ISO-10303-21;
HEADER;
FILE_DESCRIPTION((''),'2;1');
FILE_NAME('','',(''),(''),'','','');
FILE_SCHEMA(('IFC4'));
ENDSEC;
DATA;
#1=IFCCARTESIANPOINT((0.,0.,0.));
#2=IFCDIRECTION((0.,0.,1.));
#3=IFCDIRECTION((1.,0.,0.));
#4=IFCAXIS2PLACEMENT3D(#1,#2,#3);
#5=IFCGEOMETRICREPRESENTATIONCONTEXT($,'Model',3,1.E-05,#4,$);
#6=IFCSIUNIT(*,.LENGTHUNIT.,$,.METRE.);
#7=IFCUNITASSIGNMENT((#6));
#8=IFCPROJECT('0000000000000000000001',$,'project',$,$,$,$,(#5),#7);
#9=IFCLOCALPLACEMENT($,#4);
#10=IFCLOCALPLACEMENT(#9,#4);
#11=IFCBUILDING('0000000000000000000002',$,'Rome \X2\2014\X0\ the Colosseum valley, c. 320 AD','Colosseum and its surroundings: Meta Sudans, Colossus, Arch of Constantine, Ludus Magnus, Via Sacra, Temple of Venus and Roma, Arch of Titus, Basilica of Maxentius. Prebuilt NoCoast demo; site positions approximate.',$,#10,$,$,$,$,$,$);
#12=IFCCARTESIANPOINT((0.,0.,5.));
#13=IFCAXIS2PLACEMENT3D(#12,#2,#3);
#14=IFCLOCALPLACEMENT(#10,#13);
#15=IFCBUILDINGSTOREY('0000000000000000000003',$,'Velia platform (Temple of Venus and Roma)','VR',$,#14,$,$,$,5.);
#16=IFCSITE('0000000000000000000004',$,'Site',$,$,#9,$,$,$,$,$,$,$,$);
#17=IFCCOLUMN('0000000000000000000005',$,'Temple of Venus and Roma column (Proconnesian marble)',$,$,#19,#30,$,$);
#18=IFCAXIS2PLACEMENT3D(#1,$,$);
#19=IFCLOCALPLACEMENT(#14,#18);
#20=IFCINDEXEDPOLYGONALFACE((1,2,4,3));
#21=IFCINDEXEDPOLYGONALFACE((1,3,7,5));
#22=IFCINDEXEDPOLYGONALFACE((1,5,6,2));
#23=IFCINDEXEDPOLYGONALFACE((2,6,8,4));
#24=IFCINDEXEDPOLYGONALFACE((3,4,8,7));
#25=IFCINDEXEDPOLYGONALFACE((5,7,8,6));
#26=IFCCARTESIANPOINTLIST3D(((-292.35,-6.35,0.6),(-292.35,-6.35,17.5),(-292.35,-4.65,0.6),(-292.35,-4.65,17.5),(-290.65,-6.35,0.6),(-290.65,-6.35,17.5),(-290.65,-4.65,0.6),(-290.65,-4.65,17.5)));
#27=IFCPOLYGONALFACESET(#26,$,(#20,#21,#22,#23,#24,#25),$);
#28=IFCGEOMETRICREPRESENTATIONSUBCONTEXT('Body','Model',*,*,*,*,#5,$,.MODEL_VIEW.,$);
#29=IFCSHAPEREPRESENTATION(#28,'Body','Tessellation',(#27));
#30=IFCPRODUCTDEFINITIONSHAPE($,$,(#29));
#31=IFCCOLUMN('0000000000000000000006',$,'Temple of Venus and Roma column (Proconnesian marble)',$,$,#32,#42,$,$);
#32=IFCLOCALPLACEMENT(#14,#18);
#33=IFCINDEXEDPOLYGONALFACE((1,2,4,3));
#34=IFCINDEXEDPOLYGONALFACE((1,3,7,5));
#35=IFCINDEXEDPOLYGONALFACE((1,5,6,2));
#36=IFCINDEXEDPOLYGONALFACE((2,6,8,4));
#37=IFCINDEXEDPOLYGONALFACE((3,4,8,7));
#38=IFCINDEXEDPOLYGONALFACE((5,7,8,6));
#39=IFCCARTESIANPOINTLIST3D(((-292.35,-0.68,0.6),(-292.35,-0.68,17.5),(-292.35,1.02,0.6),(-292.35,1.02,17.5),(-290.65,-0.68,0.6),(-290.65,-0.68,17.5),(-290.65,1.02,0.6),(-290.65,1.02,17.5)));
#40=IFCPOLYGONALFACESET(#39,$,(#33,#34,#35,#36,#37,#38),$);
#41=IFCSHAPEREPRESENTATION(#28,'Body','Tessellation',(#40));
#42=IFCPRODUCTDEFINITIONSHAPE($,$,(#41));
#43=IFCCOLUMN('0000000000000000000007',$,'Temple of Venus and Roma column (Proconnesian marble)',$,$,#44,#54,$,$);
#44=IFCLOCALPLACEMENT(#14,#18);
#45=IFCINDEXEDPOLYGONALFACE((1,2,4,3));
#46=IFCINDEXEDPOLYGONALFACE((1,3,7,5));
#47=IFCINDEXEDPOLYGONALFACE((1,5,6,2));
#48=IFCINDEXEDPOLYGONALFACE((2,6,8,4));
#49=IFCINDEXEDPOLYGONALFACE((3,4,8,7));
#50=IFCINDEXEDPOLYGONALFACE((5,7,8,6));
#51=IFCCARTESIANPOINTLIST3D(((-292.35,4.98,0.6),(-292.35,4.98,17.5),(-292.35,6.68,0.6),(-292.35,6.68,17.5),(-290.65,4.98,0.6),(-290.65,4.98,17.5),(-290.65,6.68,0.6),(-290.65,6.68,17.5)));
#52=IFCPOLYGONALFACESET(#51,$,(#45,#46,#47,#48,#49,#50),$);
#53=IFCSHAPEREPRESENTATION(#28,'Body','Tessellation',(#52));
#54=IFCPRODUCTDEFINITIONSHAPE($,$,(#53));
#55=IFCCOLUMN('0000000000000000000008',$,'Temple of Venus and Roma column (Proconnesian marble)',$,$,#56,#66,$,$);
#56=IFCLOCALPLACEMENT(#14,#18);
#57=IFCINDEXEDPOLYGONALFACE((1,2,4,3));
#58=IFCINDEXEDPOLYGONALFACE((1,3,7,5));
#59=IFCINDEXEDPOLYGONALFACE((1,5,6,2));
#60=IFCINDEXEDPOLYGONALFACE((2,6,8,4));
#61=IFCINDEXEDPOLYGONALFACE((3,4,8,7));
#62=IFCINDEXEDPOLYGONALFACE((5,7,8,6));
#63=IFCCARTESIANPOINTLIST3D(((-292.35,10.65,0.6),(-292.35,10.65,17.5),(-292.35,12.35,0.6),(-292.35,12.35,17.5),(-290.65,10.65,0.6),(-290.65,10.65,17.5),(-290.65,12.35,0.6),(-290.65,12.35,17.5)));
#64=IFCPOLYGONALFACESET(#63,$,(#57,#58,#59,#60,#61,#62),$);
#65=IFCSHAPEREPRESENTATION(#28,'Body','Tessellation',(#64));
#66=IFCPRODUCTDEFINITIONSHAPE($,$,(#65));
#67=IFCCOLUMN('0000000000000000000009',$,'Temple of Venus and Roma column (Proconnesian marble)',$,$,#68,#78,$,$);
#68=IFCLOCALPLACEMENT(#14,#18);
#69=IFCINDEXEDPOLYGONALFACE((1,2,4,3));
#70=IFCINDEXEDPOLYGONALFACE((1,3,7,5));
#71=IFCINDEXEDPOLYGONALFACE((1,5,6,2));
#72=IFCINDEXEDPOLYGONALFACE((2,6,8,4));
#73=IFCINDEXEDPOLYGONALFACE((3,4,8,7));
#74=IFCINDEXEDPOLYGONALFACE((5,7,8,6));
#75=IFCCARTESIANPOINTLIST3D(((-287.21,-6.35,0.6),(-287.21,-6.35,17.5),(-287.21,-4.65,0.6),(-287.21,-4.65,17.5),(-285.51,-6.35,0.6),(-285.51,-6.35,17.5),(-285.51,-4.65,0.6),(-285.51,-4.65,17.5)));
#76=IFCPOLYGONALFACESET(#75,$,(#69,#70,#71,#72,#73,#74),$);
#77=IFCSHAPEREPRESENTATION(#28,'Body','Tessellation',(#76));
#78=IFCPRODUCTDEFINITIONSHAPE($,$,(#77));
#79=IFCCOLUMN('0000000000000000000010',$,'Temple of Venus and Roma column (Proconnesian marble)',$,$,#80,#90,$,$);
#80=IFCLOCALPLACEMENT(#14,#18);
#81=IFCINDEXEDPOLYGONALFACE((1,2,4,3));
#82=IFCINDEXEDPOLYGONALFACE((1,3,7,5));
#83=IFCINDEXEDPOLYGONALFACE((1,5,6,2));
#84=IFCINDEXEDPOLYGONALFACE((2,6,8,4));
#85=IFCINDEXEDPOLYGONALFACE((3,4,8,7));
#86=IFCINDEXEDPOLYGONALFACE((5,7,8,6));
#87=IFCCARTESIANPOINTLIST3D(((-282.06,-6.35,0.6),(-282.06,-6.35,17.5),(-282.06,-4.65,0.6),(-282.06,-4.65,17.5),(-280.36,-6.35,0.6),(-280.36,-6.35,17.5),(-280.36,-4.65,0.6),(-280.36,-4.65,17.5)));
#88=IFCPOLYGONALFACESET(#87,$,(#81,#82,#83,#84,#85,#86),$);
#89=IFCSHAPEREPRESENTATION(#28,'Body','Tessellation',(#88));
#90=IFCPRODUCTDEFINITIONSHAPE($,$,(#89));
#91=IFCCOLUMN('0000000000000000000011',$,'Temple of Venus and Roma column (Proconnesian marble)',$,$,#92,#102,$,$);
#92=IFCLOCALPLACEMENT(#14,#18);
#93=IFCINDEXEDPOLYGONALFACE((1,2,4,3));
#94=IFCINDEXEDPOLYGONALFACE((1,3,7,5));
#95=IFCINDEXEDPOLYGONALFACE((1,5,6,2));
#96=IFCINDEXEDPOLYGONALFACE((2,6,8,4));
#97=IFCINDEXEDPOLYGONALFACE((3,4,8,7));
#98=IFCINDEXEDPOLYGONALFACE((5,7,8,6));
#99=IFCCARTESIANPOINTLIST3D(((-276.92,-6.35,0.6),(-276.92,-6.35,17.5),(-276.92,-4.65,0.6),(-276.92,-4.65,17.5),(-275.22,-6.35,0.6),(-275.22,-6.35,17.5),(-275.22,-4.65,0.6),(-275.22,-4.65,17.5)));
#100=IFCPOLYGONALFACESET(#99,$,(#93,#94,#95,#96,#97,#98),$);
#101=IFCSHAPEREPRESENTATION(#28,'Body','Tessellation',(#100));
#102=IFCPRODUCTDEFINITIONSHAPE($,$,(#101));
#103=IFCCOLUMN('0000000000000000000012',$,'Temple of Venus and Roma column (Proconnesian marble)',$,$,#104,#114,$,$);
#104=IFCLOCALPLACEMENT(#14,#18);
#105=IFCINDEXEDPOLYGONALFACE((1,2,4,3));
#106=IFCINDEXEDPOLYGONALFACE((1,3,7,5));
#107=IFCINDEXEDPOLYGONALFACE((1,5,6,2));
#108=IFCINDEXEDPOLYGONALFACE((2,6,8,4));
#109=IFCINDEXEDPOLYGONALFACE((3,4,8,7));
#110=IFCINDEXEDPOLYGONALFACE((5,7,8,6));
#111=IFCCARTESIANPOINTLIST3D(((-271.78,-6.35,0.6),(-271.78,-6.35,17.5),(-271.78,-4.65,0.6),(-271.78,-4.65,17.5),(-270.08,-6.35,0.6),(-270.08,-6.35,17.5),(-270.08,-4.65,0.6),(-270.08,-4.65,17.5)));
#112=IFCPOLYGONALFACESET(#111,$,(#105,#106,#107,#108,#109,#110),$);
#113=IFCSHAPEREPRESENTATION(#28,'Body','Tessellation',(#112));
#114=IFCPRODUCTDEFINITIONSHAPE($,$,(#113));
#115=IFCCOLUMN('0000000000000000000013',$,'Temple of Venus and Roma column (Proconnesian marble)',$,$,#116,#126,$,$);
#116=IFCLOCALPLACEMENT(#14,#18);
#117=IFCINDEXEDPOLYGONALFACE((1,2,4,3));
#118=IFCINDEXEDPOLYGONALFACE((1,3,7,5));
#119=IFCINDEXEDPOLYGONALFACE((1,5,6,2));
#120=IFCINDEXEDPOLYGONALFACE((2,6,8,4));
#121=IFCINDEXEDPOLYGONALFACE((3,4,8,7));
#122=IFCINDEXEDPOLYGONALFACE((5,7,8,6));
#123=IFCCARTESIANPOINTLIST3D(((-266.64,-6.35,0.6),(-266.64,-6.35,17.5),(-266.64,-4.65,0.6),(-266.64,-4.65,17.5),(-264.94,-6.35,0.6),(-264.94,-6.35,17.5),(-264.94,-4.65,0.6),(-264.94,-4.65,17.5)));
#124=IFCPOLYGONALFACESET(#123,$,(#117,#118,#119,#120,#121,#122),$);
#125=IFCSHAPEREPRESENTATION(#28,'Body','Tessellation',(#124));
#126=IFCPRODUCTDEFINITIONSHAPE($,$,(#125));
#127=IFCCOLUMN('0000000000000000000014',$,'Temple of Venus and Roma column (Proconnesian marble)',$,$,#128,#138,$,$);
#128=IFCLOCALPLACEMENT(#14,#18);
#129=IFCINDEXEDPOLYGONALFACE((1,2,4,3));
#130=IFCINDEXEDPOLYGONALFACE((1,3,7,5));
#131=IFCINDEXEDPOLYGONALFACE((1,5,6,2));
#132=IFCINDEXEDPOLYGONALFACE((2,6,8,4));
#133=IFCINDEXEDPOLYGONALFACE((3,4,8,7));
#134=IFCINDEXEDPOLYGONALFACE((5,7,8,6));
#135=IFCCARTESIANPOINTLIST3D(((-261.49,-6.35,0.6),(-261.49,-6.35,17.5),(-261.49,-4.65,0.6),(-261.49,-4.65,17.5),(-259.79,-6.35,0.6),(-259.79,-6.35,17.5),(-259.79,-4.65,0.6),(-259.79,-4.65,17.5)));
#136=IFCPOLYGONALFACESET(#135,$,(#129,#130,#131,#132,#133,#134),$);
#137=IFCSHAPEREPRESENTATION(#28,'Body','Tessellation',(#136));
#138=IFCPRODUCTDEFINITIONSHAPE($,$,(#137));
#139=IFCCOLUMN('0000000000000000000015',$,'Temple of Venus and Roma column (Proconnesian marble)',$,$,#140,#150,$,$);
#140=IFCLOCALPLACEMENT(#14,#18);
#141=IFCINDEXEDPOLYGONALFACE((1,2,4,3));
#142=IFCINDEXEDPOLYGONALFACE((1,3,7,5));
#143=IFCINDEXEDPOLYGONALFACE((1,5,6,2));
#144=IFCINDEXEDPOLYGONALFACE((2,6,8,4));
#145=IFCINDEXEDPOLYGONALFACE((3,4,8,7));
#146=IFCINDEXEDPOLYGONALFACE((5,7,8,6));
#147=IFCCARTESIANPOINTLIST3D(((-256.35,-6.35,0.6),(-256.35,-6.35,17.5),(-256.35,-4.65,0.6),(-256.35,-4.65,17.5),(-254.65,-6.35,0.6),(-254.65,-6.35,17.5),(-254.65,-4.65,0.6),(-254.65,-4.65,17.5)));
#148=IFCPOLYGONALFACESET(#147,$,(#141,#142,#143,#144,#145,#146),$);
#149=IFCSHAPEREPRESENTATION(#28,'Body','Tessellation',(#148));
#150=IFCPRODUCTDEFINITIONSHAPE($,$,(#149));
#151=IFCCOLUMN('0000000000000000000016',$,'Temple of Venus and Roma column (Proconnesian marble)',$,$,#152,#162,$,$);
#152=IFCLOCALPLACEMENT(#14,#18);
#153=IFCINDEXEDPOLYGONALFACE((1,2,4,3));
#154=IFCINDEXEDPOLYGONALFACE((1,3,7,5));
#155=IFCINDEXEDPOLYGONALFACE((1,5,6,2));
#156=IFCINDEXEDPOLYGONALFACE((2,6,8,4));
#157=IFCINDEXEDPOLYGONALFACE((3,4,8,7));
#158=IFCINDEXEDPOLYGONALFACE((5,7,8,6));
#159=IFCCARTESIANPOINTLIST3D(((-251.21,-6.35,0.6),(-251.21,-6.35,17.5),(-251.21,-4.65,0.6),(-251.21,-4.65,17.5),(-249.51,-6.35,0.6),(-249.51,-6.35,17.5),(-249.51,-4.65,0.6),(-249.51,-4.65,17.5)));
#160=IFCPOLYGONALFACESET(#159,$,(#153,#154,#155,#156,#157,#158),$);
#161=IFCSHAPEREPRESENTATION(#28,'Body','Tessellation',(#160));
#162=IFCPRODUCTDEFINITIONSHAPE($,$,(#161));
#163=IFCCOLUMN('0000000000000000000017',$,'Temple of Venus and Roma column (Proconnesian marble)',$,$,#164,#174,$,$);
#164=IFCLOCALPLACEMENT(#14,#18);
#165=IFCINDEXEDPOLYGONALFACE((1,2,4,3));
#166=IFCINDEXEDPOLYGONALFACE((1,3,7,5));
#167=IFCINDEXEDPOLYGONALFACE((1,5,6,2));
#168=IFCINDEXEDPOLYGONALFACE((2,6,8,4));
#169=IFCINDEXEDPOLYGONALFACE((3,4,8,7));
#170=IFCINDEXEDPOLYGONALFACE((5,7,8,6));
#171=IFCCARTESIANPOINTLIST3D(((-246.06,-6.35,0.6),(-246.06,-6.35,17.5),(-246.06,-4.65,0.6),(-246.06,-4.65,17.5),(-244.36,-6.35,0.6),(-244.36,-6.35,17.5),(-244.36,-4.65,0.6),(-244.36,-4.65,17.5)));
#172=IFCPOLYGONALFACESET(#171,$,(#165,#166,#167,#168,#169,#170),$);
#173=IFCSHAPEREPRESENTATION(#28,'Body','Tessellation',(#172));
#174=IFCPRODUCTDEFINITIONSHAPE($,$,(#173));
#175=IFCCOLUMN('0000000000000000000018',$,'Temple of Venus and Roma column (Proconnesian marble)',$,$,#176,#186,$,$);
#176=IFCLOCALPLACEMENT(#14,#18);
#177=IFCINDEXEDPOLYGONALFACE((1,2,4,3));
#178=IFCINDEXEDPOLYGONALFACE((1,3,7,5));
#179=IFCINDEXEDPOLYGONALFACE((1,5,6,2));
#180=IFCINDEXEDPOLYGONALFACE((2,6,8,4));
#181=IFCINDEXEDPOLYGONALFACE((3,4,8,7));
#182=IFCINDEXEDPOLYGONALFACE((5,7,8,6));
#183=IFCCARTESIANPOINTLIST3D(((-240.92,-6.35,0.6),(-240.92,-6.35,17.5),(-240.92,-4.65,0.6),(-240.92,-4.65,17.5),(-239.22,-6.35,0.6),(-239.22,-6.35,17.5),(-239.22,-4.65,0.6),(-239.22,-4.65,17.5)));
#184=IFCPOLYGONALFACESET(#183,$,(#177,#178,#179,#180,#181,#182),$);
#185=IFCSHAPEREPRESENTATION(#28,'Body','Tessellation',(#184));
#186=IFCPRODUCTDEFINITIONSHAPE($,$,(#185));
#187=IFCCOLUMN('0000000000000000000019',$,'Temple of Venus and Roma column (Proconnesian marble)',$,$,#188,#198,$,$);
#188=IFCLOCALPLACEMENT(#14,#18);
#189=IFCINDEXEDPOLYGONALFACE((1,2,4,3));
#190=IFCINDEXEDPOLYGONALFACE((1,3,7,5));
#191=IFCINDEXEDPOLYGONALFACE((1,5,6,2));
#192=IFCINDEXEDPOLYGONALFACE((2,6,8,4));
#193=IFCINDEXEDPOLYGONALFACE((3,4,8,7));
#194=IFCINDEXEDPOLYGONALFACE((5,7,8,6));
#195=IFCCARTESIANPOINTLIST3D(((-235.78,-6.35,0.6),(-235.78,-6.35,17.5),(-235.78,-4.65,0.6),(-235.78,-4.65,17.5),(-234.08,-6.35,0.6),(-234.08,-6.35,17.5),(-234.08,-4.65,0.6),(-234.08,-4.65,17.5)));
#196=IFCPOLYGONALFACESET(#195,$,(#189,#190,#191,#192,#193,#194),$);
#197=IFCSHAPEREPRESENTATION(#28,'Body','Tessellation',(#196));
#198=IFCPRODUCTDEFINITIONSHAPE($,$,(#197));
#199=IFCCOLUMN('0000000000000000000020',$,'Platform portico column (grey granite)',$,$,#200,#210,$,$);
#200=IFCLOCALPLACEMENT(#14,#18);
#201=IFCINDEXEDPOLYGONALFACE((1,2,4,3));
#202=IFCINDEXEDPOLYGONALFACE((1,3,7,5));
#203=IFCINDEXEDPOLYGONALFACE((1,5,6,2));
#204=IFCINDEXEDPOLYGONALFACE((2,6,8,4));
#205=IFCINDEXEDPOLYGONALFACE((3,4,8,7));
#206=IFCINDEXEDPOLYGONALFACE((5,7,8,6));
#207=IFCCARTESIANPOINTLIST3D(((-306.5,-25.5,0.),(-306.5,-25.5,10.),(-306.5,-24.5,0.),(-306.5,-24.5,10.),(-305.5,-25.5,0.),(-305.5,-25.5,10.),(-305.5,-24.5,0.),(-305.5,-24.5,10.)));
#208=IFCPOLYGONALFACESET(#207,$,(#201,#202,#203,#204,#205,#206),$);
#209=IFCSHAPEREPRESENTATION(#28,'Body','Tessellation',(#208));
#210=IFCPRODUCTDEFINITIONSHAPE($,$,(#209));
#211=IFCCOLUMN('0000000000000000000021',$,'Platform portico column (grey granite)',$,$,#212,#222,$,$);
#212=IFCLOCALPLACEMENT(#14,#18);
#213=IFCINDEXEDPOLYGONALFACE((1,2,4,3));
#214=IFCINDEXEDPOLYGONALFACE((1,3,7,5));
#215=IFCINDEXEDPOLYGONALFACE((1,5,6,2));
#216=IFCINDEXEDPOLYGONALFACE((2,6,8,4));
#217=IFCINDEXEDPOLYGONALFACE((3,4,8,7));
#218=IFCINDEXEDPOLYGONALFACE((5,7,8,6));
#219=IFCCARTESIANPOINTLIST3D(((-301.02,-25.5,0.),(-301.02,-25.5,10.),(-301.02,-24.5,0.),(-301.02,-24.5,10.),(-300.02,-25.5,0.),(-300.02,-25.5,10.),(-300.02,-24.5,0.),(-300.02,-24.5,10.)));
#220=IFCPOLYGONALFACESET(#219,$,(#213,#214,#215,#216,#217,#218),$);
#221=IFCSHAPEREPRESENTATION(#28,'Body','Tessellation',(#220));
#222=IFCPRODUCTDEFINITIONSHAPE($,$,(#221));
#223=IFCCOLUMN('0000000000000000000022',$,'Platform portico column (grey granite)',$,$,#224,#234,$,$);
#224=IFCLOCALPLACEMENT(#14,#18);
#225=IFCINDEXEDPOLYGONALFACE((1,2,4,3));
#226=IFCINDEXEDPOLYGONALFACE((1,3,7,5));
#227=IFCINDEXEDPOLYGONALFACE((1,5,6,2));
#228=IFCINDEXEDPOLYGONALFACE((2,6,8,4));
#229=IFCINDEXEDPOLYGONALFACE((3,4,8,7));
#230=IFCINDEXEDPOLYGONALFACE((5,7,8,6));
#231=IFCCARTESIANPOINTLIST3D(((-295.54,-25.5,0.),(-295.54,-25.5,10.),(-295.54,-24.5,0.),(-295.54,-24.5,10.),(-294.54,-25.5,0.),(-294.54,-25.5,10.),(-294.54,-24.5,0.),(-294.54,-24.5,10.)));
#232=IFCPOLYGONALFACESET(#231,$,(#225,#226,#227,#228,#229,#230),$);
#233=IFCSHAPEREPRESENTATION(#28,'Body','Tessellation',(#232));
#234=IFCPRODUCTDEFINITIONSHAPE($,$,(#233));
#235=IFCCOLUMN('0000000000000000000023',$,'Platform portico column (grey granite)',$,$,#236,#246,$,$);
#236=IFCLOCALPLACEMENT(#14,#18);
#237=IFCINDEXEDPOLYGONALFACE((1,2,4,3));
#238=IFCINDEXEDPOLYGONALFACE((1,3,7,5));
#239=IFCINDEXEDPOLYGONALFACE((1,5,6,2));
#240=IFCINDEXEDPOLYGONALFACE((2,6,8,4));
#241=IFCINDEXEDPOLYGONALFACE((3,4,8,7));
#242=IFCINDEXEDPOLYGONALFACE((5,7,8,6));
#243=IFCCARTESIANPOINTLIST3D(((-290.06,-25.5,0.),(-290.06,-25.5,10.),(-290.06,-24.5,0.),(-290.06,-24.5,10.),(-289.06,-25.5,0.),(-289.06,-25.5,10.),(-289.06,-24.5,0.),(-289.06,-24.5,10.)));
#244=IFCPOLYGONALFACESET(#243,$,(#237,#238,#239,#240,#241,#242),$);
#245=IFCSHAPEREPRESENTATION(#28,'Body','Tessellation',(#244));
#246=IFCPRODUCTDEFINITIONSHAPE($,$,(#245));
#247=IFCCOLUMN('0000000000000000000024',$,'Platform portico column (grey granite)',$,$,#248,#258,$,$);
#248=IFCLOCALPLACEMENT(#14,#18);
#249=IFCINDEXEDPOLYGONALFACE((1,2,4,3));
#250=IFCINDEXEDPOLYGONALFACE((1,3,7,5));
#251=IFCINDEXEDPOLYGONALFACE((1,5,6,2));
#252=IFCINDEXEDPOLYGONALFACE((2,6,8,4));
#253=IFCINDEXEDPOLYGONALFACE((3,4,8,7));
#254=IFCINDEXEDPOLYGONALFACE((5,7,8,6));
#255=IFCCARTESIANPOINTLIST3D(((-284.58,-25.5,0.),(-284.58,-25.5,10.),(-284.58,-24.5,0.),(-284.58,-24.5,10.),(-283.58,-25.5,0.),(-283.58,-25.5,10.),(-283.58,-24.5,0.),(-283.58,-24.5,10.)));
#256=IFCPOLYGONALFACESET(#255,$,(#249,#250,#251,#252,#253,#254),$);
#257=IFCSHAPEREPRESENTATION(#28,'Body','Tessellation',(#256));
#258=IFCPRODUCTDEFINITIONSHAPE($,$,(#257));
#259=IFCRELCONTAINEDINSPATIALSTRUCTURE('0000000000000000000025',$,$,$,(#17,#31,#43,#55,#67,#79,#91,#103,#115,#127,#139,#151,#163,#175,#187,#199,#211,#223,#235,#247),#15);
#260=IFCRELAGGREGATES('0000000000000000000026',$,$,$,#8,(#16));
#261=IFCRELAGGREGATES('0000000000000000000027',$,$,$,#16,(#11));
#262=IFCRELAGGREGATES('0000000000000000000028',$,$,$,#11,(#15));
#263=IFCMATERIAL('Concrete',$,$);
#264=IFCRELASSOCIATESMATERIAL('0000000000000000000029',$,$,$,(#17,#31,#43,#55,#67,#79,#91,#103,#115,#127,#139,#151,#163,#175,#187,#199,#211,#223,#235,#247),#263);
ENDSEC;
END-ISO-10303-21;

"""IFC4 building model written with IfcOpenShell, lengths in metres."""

from ifc_helpers import new_model, si_unit, frame, origin_with_axes, place, context, subcontext, project, spatial, indexed_curve, outline, extrude, material, element, save


model = new_model("IFC4")

# Units and contexts
model_context = context("Model", 3, precision=1e-05, world=origin_with_axes())
body_context = subcontext(model_context, "Body", "Model", "MODEL_VIEW")
ifc_project = project(units=[si_unit("LENGTHUNIT", "METRE")], contexts=[model_context])

# Site, building, storey
site_placement = place(None, origin_with_axes())
site = spatial("IfcSite", under=ifc_project, at=site_placement, Name="Site")
building_placement = place(site_placement, origin_with_axes())
building = spatial("IfcBuilding", under=site, at=building_placement, Name="Rome — the Colosseum valley, c. 320 AD", Description="Colosseum and its surroundings: Meta Sudans, Colossus, Arch of Constantine, Ludus Magnus, Via Sacra, Temple of Venus and Roma, Arch of Titus, Basilica of Maxentius. Prebuilt NoCoast demo; site positions approximate.")
storey_placement = place(building_placement, frame((0.0, 0.0, 5.0), z_axis=(0.0, 0.0, 1.0), x_axis=(1.0, 0.0, 0.0)))
storey = spatial("IfcBuildingStorey", under=building, at=storey_placement, Name="Velia platform (Temple of Venus and Roma)", Description="VR", Elevation=5.0)

# Columns
ifc_material_1 = material(Name="Concrete")
for number, where, z_axis, x_axis, name in (
    (1, (-292.35, -5.5, 0.6), (0.0, 0.0, 1.0), (1.0, 0.0, 0.0), "Temple of Venus and Roma column (Proconnesian marble)"),
    (2, (-292.35, 0.17, 0.6), (0.0, 0.0, 1.0), (1.0, 0.0, 0.0), "Temple of Venus and Roma column (Proconnesian marble)"),
    (3, (-292.35, 5.83, 0.6), (0.0, 0.0, 1.0), (1.0, 0.0, 0.0), "Temple of Venus and Roma column (Proconnesian marble)"),
    (4, (-292.35, 11.5, 0.6), (0.0, 0.0, 1.0), (1.0, 0.0, 0.0), "Temple of Venus and Roma column (Proconnesian marble)"),
    (5, (-287.21, -5.5, 0.6), (0.0, 0.0, 1.0), (1.0, 0.0, 0.0), "Temple of Venus and Roma column (Proconnesian marble)"),
    (6, (-282.06, -5.5, 0.6), (0.0, 0.0, 1.0), (1.0, 0.0, 0.0), "Temple of Venus and Roma column (Proconnesian marble)"),
    (7, (-276.92, -5.5, 0.6), (0.0, 0.0, 1.0), (1.0, 0.0, 0.0), "Temple of Venus and Roma column (Proconnesian marble)"),
    (8, (-271.78, -5.5, 0.6), (0.0, 0.0, 1.0), (1.0, 0.0, 0.0), "Temple of Venus and Roma column (Proconnesian marble)"),
    (9, (-266.64, -5.5, 0.6), (0.0, 0.0, 1.0), (1.0, 0.0, 0.0), "Temple of Venus and Roma column (Proconnesian marble)"),
    (10, (-261.49, -5.5, 0.6), (0.0, 0.0, 1.0), (1.0, 0.0, 0.0), "Temple of Venus and Roma column (Proconnesian marble)"),
    (11, (-256.35, -5.5, 0.6), (0.0, 0.0, 1.0), (1.0, 0.0, 0.0), "Temple of Venus and Roma column (Proconnesian marble)"),
    (12, (-251.21, -5.5, 0.6), (0.0, 0.0, 1.0), (1.0, 0.0, 0.0), "Temple of Venus and Roma column (Proconnesian marble)"),
    (13, (-246.06, -5.5, 0.6), (0.0, 0.0, 1.0), (1.0, 0.0, 0.0), "Temple of Venus and Roma column (Proconnesian marble)"),
    (14, (-240.92, -5.5, 0.6), (0.0, 0.0, 1.0), (1.0, 0.0, 0.0), "Temple of Venus and Roma column (Proconnesian marble)"),
    (15, (-235.78, -5.5, 0.6), (0.0, 0.0, 1.0), (1.0, 0.0, 0.0), "Temple of Venus and Roma column (Proconnesian marble)"),
):
    element("IfcColumn", number, at=place(storey_placement, frame(where, z_axis=z_axis, x_axis=x_axis)), inside=storey, material=ifc_material_1, Name=name, context=body_context, shape_type="SweptSolid", body=[
        extrude(outline(indexed_curve([(0.0, 0.0), (0.0, 1.7), (1.7, 1.7), (1.7, 0.0), (0.0, 0.0)], self_intersect=False)), frame((0.0, -0.85, 0.0), z_axis=(0.0, 0.0, 1.0), x_axis=(1.0, 0.0, 0.0)), (0.0, 0.0, 1.0), 16.9),
    ])
for number, where, z_axis, x_axis, name in (
    (16, (-306.5, -25.0, 0.0), (0.0, 0.0, 1.0), (1.0, 0.0, 0.0), "Platform portico column (grey granite)"),
    (17, (-301.02, -25.0, 0.0), (0.0, 0.0, 1.0), (1.0, 0.0, 0.0), "Platform portico column (grey granite)"),
    (18, (-295.54, -25.0, 0.0), (0.0, 0.0, 1.0), (1.0, 0.0, 0.0), "Platform portico column (grey granite)"),
    (19, (-290.06, -25.0, 0.0), (0.0, 0.0, 1.0), (1.0, 0.0, 0.0), "Platform portico column (grey granite)"),
    (20, (-284.58, -25.0, 0.0), (0.0, 0.0, 1.0), (1.0, 0.0, 0.0), "Platform portico column (grey granite)"),
):
    element("IfcColumn", number, at=place(storey_placement, frame(where, z_axis=z_axis, x_axis=x_axis)), inside=storey, material=ifc_material_1, Name=name, context=body_context, shape_type="SweptSolid", body=[
        extrude(outline(indexed_curve([(0.0, 0.0), (0.0, 1.0), (1.0, 1.0), (1.0, 0.0), (0.0, 0.0)], self_intersect=False)), frame((0.0, -0.5, 0.0), z_axis=(0.0, 0.0, 1.0), x_axis=(1.0, 0.0, 0.0)), (0.0, 0.0, 1.0), 10.0),
    ])

save(model, "model.ifc")
